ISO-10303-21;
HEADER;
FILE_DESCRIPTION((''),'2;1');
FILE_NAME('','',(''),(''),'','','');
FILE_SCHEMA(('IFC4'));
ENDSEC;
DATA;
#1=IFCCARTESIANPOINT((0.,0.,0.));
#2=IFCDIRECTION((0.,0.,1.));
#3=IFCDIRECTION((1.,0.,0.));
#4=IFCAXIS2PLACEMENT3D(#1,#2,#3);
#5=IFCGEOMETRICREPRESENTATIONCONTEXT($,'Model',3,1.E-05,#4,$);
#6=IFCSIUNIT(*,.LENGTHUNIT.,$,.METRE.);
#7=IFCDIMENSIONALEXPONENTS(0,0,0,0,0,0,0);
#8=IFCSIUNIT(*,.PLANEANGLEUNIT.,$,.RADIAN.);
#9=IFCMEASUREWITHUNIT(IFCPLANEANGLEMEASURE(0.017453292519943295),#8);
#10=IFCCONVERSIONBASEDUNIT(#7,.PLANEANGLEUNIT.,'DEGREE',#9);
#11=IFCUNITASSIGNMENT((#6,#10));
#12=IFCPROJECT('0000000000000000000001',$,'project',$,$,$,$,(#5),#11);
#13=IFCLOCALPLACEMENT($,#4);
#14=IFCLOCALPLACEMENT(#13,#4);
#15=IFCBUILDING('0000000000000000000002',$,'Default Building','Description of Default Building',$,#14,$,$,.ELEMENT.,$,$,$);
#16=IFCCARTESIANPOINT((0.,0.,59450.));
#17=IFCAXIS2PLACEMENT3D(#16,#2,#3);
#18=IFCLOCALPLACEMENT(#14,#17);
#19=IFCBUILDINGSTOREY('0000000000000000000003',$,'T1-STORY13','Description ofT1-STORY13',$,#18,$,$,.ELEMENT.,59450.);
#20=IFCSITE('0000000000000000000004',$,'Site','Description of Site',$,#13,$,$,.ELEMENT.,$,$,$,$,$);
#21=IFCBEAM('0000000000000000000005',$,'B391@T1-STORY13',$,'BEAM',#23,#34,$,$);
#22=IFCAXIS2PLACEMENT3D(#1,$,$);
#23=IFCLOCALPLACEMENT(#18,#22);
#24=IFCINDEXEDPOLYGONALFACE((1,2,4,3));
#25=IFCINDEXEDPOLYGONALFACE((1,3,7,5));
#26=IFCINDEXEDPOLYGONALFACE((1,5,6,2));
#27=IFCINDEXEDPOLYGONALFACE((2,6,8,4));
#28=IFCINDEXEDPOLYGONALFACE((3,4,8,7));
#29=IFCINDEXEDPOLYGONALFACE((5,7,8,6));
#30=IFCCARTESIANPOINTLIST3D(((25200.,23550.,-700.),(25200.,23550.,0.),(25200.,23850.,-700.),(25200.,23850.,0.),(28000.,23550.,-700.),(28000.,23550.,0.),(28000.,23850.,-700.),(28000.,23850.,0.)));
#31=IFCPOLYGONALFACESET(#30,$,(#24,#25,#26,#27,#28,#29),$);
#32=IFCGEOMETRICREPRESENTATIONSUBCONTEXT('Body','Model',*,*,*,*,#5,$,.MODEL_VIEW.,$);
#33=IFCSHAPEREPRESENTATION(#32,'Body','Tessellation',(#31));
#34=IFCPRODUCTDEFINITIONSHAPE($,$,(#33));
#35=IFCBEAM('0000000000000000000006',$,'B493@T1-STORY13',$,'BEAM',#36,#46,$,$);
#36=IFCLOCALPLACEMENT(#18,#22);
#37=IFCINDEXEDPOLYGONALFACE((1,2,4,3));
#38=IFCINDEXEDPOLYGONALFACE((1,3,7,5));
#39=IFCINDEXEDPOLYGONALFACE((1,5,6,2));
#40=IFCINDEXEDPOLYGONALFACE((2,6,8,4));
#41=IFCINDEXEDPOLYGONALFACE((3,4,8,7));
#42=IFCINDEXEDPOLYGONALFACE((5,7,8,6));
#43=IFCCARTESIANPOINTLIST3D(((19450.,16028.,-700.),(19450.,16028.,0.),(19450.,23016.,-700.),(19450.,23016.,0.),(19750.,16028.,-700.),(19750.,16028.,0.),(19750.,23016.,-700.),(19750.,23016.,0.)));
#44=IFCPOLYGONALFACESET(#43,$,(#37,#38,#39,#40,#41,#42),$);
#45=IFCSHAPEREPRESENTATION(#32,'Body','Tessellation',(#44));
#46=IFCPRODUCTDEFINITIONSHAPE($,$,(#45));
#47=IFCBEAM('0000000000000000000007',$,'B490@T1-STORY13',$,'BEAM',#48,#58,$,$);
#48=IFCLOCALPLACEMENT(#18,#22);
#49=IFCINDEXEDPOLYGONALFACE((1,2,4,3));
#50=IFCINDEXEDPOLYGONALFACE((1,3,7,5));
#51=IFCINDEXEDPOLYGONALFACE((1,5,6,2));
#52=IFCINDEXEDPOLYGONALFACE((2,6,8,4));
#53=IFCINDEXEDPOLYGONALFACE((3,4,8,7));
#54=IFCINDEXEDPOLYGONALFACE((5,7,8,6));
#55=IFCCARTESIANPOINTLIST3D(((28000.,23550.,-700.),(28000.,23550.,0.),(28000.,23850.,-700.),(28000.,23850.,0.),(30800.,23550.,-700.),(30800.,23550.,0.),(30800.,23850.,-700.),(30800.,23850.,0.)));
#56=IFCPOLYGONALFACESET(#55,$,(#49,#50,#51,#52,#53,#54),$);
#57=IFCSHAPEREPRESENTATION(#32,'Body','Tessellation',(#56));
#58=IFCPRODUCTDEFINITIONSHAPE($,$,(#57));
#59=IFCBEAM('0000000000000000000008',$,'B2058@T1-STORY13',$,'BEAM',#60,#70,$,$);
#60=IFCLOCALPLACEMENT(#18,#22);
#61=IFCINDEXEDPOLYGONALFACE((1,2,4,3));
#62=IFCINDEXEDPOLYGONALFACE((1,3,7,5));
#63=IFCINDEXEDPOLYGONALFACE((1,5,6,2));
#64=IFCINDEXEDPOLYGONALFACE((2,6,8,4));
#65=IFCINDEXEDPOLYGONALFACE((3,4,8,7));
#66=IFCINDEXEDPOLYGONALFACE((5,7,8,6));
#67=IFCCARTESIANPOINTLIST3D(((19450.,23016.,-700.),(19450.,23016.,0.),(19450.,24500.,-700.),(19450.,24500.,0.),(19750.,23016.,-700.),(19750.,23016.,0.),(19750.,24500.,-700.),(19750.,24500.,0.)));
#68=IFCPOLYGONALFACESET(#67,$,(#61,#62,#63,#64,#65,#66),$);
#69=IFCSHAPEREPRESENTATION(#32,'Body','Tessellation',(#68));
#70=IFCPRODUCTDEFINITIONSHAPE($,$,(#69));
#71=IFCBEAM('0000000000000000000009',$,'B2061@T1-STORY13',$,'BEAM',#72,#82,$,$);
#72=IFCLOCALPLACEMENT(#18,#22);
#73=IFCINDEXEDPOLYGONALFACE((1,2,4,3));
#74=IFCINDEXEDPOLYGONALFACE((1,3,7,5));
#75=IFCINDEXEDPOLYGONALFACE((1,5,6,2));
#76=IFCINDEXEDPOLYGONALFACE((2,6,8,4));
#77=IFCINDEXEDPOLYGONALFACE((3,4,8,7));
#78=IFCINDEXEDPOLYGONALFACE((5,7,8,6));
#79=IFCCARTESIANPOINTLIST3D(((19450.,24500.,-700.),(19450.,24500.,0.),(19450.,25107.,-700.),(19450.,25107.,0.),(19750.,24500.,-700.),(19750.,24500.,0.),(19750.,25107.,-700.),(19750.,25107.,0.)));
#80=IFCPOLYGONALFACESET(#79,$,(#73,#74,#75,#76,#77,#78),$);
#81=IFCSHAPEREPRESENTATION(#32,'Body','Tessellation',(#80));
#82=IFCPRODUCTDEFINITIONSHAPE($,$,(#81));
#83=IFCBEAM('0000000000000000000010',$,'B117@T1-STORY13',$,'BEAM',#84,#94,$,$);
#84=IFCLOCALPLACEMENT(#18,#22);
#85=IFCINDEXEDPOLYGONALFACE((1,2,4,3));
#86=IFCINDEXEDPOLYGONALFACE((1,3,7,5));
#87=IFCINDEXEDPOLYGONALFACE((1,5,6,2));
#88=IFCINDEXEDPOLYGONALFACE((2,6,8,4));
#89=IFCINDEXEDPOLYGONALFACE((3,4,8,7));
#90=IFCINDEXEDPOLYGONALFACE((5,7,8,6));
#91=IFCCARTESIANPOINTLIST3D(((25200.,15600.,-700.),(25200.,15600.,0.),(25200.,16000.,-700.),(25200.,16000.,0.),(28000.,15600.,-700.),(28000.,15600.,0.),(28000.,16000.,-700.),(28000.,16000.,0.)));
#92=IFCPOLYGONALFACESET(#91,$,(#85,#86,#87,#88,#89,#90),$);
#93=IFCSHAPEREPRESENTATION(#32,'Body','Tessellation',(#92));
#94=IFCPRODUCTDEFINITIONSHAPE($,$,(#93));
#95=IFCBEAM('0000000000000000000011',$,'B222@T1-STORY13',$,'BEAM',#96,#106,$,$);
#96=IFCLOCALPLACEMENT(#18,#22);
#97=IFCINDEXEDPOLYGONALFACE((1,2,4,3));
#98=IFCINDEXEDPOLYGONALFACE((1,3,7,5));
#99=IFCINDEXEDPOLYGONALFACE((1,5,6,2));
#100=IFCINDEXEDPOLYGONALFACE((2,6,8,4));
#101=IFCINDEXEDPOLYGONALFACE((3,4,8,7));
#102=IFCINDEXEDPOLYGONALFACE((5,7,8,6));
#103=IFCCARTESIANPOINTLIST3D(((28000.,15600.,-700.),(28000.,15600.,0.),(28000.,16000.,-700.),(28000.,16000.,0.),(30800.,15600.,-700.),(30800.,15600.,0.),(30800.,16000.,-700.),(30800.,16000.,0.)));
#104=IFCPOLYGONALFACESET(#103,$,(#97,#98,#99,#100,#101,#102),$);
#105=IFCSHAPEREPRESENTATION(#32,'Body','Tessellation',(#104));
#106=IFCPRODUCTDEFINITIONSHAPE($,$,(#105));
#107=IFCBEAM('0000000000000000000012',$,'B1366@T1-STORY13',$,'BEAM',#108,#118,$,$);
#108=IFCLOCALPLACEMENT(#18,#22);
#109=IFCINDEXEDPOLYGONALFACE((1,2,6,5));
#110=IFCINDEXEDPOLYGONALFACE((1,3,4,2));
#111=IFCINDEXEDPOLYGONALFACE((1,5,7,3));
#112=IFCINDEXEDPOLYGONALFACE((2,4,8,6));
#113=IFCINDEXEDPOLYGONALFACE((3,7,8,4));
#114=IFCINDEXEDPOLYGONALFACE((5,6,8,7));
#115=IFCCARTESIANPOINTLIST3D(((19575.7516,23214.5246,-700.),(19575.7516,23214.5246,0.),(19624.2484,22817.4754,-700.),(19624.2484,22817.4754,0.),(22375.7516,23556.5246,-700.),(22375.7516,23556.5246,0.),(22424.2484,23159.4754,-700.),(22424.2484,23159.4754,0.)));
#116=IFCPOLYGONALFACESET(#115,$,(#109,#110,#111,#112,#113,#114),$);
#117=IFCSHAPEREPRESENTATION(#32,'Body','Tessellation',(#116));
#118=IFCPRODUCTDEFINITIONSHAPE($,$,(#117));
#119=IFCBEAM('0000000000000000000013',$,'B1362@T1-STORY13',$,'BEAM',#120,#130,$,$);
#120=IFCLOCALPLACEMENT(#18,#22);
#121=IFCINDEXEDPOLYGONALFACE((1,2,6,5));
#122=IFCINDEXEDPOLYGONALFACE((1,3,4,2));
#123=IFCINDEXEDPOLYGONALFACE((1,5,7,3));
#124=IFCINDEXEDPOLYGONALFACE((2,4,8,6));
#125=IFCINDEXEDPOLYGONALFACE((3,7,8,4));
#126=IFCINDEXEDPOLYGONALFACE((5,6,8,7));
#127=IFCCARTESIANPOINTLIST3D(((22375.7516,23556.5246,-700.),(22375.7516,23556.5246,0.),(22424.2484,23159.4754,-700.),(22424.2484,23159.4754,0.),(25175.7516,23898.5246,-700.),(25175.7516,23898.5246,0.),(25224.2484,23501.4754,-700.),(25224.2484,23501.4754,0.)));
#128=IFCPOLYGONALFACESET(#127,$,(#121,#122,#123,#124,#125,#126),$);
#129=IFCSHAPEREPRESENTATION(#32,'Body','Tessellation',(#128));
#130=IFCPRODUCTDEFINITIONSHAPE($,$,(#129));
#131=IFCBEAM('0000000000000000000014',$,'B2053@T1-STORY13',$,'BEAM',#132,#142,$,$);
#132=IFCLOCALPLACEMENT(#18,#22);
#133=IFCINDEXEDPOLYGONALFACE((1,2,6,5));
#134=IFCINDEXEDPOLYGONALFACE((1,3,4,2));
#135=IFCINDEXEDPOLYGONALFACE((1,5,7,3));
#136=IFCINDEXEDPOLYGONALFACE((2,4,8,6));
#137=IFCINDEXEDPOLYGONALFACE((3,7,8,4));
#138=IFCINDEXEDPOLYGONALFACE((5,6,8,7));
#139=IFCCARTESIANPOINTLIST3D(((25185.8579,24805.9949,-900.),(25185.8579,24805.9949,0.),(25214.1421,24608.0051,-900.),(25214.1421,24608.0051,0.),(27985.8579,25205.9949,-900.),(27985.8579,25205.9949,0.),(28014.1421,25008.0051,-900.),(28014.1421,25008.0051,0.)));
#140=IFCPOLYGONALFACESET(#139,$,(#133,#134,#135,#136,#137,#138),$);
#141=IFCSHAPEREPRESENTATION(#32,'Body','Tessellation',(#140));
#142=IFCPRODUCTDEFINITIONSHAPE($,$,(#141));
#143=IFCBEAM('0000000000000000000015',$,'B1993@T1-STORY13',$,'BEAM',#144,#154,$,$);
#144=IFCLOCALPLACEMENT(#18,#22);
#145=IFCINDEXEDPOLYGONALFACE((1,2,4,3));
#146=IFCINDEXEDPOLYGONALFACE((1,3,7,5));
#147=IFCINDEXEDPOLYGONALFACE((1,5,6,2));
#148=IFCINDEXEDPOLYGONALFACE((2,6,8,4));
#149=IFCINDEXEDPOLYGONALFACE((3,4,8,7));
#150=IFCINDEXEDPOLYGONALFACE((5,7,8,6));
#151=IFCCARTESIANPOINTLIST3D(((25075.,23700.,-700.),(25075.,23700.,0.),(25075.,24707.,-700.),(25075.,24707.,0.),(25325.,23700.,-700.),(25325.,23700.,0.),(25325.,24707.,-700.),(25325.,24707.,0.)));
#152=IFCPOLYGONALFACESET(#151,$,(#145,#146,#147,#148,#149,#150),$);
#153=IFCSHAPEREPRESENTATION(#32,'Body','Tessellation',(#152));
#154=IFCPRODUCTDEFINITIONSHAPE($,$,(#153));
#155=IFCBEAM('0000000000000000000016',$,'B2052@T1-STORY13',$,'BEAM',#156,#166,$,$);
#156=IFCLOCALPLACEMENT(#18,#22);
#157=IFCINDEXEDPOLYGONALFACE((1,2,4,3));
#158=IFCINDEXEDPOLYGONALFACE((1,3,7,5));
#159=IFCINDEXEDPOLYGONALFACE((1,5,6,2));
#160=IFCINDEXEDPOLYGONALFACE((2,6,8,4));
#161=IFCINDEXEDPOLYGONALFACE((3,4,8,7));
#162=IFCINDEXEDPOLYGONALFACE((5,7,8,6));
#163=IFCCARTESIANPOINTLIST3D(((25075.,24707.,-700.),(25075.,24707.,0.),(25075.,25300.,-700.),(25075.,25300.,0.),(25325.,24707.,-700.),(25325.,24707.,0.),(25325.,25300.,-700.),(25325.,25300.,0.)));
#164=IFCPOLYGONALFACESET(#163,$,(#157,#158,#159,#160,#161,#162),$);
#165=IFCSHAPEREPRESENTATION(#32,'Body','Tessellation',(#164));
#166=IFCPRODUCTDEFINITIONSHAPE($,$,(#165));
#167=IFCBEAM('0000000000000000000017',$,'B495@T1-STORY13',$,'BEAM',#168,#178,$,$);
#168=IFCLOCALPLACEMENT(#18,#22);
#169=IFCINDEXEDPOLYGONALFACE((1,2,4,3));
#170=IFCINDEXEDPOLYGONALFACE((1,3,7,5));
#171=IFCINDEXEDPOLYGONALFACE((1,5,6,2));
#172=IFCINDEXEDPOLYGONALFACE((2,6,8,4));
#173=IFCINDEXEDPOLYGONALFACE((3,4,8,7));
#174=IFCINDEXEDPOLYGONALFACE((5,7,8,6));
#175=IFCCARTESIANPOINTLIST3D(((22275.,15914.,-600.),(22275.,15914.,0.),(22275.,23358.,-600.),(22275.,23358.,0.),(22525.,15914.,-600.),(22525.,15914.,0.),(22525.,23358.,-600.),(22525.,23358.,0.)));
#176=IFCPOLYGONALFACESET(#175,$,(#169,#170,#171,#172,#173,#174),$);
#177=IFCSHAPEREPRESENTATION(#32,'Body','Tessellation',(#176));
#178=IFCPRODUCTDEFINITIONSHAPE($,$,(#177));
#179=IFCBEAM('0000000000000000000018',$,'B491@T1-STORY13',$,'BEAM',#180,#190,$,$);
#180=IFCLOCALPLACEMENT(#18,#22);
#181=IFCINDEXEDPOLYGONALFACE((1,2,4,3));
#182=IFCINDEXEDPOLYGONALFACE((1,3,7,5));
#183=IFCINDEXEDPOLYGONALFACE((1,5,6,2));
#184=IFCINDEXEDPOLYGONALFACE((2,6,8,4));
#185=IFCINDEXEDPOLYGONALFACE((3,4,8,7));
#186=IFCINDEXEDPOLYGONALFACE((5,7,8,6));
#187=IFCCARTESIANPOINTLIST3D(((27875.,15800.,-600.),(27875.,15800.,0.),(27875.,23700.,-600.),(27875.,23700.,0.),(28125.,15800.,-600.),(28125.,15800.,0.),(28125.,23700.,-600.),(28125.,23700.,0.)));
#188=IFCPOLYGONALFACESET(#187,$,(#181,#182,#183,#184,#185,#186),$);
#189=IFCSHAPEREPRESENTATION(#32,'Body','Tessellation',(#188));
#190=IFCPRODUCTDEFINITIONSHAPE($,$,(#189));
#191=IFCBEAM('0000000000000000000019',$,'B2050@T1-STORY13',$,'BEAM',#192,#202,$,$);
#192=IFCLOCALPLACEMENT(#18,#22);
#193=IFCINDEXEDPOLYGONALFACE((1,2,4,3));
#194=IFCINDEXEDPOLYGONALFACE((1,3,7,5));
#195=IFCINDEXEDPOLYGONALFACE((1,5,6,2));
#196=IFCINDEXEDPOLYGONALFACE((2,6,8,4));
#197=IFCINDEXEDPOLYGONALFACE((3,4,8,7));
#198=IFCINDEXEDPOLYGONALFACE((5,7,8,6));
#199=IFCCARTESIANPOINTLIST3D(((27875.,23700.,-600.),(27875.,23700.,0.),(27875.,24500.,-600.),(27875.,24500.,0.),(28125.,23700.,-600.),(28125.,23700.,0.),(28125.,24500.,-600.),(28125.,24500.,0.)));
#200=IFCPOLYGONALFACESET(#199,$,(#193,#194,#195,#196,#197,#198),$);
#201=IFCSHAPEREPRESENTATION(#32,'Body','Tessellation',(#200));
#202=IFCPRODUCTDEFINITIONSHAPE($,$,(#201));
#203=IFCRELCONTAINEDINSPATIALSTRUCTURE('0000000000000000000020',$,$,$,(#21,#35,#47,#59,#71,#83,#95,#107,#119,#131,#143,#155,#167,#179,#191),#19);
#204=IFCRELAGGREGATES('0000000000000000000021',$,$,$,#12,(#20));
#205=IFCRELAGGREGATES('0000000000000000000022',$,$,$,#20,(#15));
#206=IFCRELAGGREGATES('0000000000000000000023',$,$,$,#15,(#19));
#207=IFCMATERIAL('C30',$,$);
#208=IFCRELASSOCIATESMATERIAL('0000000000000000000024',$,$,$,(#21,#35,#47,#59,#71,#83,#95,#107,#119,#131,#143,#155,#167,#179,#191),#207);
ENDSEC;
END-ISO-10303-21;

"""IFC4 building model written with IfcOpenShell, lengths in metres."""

from ifc_helpers import new_model, entity, si_unit, converted_unit, frame, origin_with_axes, place, context, subcontext, project, spatial, rectangle, extrude, material, element, save


model = new_model("IFC4")

# Units and contexts
model_context = context("Model", 3, precision=1e-05, world=origin_with_axes())
body_context = subcontext(model_context, "Body", "Model", "MODEL_VIEW")
ifc_project = project(units=[si_unit("LENGTHUNIT", "METRE"), converted_unit("PLANEANGLEUNIT", "DEGREE", entity("IfcPlaneAngleMeasure", 0.017453292519943295), si_unit("PLANEANGLEUNIT", "RADIAN"), dimensions=[0, 0, 0, 0, 0, 0, 0])], contexts=[model_context])

# Site, building, storey
site_placement = place(None, origin_with_axes())
site = spatial("IfcSite", under=ifc_project, at=site_placement, Name="Site", Description="Description of Site", CompositionType="ELEMENT")
building_placement = place(site_placement, origin_with_axes())
building = spatial("IfcBuilding", under=site, at=building_placement, Name="Default Building", Description="Description of Default Building", CompositionType="ELEMENT")
storey_placement = place(building_placement, frame((0.0, 0.0, 59450.0), z_axis=(0.0, 0.0, 1.0), x_axis=(1.0, 0.0, 0.0)))
storey = spatial("IfcBuildingStorey", under=building, at=storey_placement, Name="T1-STORY13", Description="Description ofT1-STORY13", CompositionType="ELEMENT", Elevation=59450.0)

# Beams
ifc_material_1 = material(Name="C30")
beam_1_placement = place(storey_placement, frame((25200.0, 23700.0, -350.0), z_axis=(1.0, 0.0, 0.0), x_axis=(0.0, 1.0, 0.0)))
element("IfcBeam", 1, at=beam_1_placement, inside=storey, material=ifc_material_1, Name="B391@T1-STORY13", ObjectType="BEAM", context=body_context, shape_type="SweptSolid", body=[
    extrude(rectangle(XDim=300.0, YDim=700.0), origin_with_axes(), (0.0, 0.0, 1.0), 2800.0),
])
beam_2_placement = place(storey_placement, frame((19600.0, 16028.0, -350.0), z_axis=(0.0, 1.0, 0.0), x_axis=(-1.0, 0.0, 0.0)))
element("IfcBeam", 2, at=beam_2_placement, inside=storey, material=ifc_material_1, Name="B493@T1-STORY13", ObjectType="BEAM", context=body_context, shape_type="SweptSolid", body=[
    extrude(rectangle(XDim=300.0, YDim=700.0), origin_with_axes(), (0.0, 0.0, 1.0), 6988.0),
])
beam_3_placement = place(storey_placement, frame((28000.0, 23700.0, -350.0), z_axis=(1.0, 0.0, 0.0), x_axis=(0.0, 1.0, 0.0)))
element("IfcBeam", 3, at=beam_3_placement, inside=storey, material=ifc_material_1, Name="B490@T1-STORY13", ObjectType="BEAM", context=body_context, shape_type="SweptSolid", body=[
    extrude(rectangle(XDim=300.0, YDim=700.0), origin_with_axes(), (0.0, 0.0, 1.0), 2800.0),
])
beam_4_placement = place(storey_placement, frame((19600.0, 23016.0, -350.0), z_axis=(0.0, 1.0, 0.0), x_axis=(-1.0, 0.0, 0.0)))
element("IfcBeam", 4, at=beam_4_placement, inside=storey, material=ifc_material_1, Name="B2058@T1-STORY13", ObjectType="BEAM", context=body_context, shape_type="SweptSolid", body=[
    extrude(rectangle(XDim=300.0, YDim=700.0), origin_with_axes(), (0.0, 0.0, 1.0), 1484.0),
])
beam_5_placement = place(storey_placement, frame((19600.0, 24500.0, -350.0), z_axis=(0.0, 1.0, 0.0), x_axis=(-1.0, 0.0, 0.0)))
element("IfcBeam", 5, at=beam_5_placement, inside=storey, material=ifc_material_1, Name="B2061@T1-STORY13", ObjectType="BEAM", context=body_context, shape_type="SweptSolid", body=[
    extrude(rectangle(XDim=300.0, YDim=700.0), origin_with_axes(), (0.0, 0.0, 1.0), 607.0),
])
beam_6_placement = place(storey_placement, frame((25200.0, 15800.0, -350.0), z_axis=(1.0, 0.0, 0.0), x_axis=(0.0, 1.0, 0.0)))
element("IfcBeam", 6, at=beam_6_placement, inside=storey, material=ifc_material_1, Name="B117@T1-STORY13", ObjectType="BEAM", context=body_context, shape_type="SweptSolid", body=[
    extrude(rectangle(XDim=400.0, YDim=700.0), origin_with_axes(), (0.0, 0.0, 1.0), 2800.0),
])
beam_7_placement = place(storey_placement, frame((28000.0, 15800.0, -350.0), z_axis=(1.0, 0.0, 0.0), x_axis=(0.0, 1.0, 0.0)))
element("IfcBeam", 7, at=beam_7_placement, inside=storey, material=ifc_material_1, Name="B222@T1-STORY13", ObjectType="BEAM", context=body_context, shape_type="SweptSolid", body=[
    extrude(rectangle(XDim=400.0, YDim=700.0), origin_with_axes(), (0.0, 0.0, 1.0), 2800.0),
])
beam_8_placement = place(storey_placement, frame((19600.0, 23016.0, -350.0), z_axis=(0.992623, 0.121242, 0.0), x_axis=(-0.121242, 0.992623, 0.0)))
element("IfcBeam", 8, at=beam_8_placement, inside=storey, material=ifc_material_1, Name="B1366@T1-STORY13", ObjectType="BEAM", context=body_context, shape_type="SweptSolid", body=[
    extrude(rectangle(XDim=400.0, YDim=700.0), origin_with_axes(), (0.0, 0.0, 1.0), 2820.8091),
])
beam_9_placement = place(storey_placement, frame((22400.0, 23358.0, -350.0), z_axis=(0.992623, 0.121242, 0.0), x_axis=(-0.121242, 0.992623, 0.0)))
element("IfcBeam", 9, at=beam_9_placement, inside=storey, material=ifc_material_1, Name="B1362@T1-STORY13", ObjectType="BEAM", context=body_context, shape_type="SweptSolid", body=[
    extrude(rectangle(XDim=400.0, YDim=700.0), origin_with_axes(), (0.0, 0.0, 1.0), 2820.8091),
])
beam_10_placement = place(storey_placement, frame((25200.0, 24707.0, -450.0), z_axis=(0.989949, 0.141421, 0.0), x_axis=(-0.141421, 0.989949, 0.0)))
element("IfcBeam", 10, at=beam_10_placement, inside=storey, material=ifc_material_1, Name="B2053@T1-STORY13", ObjectType="BEAM", context=body_context, shape_type="SweptSolid", body=[
    extrude(rectangle(XDim=200.0, YDim=900.0), origin_with_axes(), (0.0, 0.0, 1.0), 2828.4271),
])
beam_11_placement = place(storey_placement, frame((25200.0, 23700.0, -350.0), z_axis=(0.0, 1.0, 0.0), x_axis=(-1.0, 0.0, 0.0)))
element("IfcBeam", 11, at=beam_11_placement, inside=storey, material=ifc_material_1, Name="B1993@T1-STORY13", ObjectType="BEAM", context=body_context, shape_type="SweptSolid", body=[
    extrude(rectangle(XDim=250.0, YDim=700.0), origin_with_axes(), (0.0, 0.0, 1.0), 1007.0),
])
beam_12_placement = place(storey_placement, frame((25200.0, 24707.0, -350.0), z_axis=(0.0, 1.0, 0.0), x_axis=(-1.0, 0.0, 0.0)))
element("IfcBeam", 12, at=beam_12_placement, inside=storey, material=ifc_material_1, Name="B2052@T1-STORY13", ObjectType="BEAM", context=body_context, shape_type="SweptSolid", body=[
    extrude(rectangle(XDim=250.0, YDim=700.0), origin_with_axes(), (0.0, 0.0, 1.0), 593.0),
])
beam_13_placement = place(storey_placement, frame((22400.0, 15914.0, -300.0), z_axis=(0.0, 1.0, 0.0), x_axis=(-1.0, 0.0, 0.0)))
element("IfcBeam", 13, at=beam_13_placement, inside=storey, material=ifc_material_1, Name="B495@T1-STORY13", ObjectType="BEAM", context=body_context, shape_type="SweptSolid", body=[
    extrude(rectangle(XDim=250.0, YDim=600.0), origin_with_axes(), (0.0, 0.0, 1.0), 7444.0),
])
beam_14_placement = place(storey_placement, frame((28000.0, 15800.0, -300.0), z_axis=(0.0, 1.0, 0.0), x_axis=(-1.0, 0.0, 0.0)))
element("IfcBeam", 14, at=beam_14_placement, inside=storey, material=ifc_material_1, Name="B491@T1-STORY13", ObjectType="BEAM", context=body_context, shape_type="SweptSolid", body=[
    extrude(rectangle(XDim=250.0, YDim=600.0), origin_with_axes(), (0.0, 0.0, 1.0), 7900.0),
])
beam_15_placement = place(storey_placement, frame((28000.0, 23700.0, -300.0), z_axis=(0.0, 1.0, 0.0), x_axis=(-1.0, 0.0, 0.0)))
element("IfcBeam", 15, at=beam_15_placement, inside=storey, material=ifc_material_1, Name="B2050@T1-STORY13", ObjectType="BEAM", context=body_context, shape_type="SweptSolid", body=[
    extrude(rectangle(XDim=250.0, YDim=600.0), origin_with_axes(), (0.0, 0.0, 1.0), 800.0),
])

save(model, "model.ifc")
